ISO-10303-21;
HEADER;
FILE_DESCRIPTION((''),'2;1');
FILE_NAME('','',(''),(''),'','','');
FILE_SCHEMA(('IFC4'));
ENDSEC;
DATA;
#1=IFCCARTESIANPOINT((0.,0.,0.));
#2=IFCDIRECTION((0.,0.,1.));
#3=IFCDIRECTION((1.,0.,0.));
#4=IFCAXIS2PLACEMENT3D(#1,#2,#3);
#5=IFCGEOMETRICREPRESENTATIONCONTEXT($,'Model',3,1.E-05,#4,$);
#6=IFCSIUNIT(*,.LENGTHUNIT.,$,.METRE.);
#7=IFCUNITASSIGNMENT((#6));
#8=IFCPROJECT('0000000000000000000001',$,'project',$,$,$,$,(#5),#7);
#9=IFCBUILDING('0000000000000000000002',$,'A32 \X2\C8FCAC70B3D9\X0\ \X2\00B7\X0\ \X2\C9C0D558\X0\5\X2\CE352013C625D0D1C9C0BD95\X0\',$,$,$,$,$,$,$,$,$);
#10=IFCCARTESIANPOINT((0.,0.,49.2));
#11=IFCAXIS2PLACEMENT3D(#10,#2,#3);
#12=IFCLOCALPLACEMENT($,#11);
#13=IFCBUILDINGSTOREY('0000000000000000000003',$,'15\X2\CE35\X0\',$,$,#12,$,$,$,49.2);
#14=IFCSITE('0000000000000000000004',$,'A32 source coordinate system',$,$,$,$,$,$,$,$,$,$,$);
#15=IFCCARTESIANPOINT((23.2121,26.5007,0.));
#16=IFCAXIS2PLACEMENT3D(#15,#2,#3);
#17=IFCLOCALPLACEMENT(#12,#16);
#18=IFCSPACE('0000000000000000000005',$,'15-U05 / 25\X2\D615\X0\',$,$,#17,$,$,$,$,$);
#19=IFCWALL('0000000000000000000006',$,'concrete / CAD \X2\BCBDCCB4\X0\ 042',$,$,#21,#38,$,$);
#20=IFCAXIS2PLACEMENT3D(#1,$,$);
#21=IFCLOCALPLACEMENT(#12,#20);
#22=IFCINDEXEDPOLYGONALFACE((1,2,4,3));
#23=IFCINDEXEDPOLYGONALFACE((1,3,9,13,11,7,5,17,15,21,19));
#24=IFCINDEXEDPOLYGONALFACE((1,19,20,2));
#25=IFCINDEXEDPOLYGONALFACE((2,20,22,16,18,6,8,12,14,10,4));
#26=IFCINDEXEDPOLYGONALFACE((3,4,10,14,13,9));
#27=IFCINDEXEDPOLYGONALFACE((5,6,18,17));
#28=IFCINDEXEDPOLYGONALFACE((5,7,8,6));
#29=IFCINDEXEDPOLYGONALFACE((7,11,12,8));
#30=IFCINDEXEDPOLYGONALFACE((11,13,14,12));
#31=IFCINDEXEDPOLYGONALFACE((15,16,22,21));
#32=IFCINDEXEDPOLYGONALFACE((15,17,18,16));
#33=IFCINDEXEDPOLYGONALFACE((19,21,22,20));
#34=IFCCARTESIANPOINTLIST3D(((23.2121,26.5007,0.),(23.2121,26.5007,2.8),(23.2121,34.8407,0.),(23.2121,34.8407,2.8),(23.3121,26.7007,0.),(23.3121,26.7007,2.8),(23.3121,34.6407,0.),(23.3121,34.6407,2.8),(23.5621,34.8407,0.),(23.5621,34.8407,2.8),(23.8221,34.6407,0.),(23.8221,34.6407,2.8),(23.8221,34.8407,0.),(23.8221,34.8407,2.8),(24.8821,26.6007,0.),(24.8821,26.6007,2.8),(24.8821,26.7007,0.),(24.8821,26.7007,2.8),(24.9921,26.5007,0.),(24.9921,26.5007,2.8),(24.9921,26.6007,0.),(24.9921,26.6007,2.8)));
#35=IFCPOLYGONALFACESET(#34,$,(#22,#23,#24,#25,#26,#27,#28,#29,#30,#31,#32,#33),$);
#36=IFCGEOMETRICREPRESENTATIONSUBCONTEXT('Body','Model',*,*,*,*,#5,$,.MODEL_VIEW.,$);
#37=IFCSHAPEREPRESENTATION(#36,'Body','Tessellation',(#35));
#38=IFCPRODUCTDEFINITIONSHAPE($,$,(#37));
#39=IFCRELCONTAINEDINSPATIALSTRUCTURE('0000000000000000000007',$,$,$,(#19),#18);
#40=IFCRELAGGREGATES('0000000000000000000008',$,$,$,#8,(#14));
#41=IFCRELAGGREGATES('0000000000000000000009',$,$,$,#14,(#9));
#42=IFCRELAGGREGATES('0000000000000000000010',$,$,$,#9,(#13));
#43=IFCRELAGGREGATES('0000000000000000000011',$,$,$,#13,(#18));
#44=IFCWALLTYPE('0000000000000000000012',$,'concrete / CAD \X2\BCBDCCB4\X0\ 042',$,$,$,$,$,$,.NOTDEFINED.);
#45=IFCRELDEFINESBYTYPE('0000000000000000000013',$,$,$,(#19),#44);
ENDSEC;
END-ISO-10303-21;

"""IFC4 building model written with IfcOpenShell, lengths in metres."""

from ifc_helpers import new_model, si_unit, frame, origin, origin_with_axes, place, context, subcontext, project, spatial, polyline, outline, extrude, source, transform, mapped, type_object, type_shapes, element, save


model = new_model("IFC4")

# Units and contexts
model_context = context("Model", 3, precision=1e-05, world=origin_with_axes())
body_context = subcontext(model_context, "Body", "Model", "MODEL_VIEW")
ifc_project = project(units=[si_unit("LENGTHUNIT", "METRE")], contexts=[model_context])

# Site, building, storey, space
site = spatial("IfcSite", under=ifc_project, Name="A32 source coordinate system")
building = spatial("IfcBuilding", under=site, Name="A32 주거동 · 지하5층–옥탑지붕")
storey_placement = place(None, frame((0.0, 0.0, 49.2), z_axis=(0.0, 0.0, 1.0), x_axis=(1.0, 0.0, 0.0)))
storey = spatial("IfcBuildingStorey", under=building, at=storey_placement, Name="15층", Elevation=49.2)
space_1_placement = place(storey_placement, frame((23.2121, 26.5007, 0.0), z_axis=(0.0, 0.0, 1.0), x_axis=(1.0, 0.0, 0.0)))
space_1 = spatial("IfcSpace", under=storey, at=space_1_placement, Name="15-U05 / 25형")

# Wall
wall_type_1 = type_object("IfcWallType", Name="concrete / CAD 벽체 042", PredefinedType="NOTDEFINED")
shared_shape_1 = source(origin(), body_context, "Body", "SweptSolid", [
    extrude(outline(polyline([(0.1, 8.14), (0.1, 0.2), (1.67, 0.2), (1.67, 0.1), (1.78, 0.1), (1.78, 0.0), (0.0, 0.0), (0.0, 8.34), (0.35, 8.34), (0.35, 8.34), (0.61, 8.34), (0.61, 8.14), (0.1, 8.14)])), origin(), (0.0, 0.0, 1.0), 2.8),
])
type_shapes(wall_type_1, [shared_shape_1])
wall_1_placement = place(space_1_placement, origin_with_axes())
element("IfcWall", 1, at=wall_1_placement, inside=space_1, type_object=wall_type_1, Name="concrete / CAD 벽체 042", context=body_context, shape_type="MappedRepresentation", body=[
    mapped(shared_shape_1, transform((0.0, 0.0, 0.0), scale=1.0)),
])

save(model, "model.ifc")
